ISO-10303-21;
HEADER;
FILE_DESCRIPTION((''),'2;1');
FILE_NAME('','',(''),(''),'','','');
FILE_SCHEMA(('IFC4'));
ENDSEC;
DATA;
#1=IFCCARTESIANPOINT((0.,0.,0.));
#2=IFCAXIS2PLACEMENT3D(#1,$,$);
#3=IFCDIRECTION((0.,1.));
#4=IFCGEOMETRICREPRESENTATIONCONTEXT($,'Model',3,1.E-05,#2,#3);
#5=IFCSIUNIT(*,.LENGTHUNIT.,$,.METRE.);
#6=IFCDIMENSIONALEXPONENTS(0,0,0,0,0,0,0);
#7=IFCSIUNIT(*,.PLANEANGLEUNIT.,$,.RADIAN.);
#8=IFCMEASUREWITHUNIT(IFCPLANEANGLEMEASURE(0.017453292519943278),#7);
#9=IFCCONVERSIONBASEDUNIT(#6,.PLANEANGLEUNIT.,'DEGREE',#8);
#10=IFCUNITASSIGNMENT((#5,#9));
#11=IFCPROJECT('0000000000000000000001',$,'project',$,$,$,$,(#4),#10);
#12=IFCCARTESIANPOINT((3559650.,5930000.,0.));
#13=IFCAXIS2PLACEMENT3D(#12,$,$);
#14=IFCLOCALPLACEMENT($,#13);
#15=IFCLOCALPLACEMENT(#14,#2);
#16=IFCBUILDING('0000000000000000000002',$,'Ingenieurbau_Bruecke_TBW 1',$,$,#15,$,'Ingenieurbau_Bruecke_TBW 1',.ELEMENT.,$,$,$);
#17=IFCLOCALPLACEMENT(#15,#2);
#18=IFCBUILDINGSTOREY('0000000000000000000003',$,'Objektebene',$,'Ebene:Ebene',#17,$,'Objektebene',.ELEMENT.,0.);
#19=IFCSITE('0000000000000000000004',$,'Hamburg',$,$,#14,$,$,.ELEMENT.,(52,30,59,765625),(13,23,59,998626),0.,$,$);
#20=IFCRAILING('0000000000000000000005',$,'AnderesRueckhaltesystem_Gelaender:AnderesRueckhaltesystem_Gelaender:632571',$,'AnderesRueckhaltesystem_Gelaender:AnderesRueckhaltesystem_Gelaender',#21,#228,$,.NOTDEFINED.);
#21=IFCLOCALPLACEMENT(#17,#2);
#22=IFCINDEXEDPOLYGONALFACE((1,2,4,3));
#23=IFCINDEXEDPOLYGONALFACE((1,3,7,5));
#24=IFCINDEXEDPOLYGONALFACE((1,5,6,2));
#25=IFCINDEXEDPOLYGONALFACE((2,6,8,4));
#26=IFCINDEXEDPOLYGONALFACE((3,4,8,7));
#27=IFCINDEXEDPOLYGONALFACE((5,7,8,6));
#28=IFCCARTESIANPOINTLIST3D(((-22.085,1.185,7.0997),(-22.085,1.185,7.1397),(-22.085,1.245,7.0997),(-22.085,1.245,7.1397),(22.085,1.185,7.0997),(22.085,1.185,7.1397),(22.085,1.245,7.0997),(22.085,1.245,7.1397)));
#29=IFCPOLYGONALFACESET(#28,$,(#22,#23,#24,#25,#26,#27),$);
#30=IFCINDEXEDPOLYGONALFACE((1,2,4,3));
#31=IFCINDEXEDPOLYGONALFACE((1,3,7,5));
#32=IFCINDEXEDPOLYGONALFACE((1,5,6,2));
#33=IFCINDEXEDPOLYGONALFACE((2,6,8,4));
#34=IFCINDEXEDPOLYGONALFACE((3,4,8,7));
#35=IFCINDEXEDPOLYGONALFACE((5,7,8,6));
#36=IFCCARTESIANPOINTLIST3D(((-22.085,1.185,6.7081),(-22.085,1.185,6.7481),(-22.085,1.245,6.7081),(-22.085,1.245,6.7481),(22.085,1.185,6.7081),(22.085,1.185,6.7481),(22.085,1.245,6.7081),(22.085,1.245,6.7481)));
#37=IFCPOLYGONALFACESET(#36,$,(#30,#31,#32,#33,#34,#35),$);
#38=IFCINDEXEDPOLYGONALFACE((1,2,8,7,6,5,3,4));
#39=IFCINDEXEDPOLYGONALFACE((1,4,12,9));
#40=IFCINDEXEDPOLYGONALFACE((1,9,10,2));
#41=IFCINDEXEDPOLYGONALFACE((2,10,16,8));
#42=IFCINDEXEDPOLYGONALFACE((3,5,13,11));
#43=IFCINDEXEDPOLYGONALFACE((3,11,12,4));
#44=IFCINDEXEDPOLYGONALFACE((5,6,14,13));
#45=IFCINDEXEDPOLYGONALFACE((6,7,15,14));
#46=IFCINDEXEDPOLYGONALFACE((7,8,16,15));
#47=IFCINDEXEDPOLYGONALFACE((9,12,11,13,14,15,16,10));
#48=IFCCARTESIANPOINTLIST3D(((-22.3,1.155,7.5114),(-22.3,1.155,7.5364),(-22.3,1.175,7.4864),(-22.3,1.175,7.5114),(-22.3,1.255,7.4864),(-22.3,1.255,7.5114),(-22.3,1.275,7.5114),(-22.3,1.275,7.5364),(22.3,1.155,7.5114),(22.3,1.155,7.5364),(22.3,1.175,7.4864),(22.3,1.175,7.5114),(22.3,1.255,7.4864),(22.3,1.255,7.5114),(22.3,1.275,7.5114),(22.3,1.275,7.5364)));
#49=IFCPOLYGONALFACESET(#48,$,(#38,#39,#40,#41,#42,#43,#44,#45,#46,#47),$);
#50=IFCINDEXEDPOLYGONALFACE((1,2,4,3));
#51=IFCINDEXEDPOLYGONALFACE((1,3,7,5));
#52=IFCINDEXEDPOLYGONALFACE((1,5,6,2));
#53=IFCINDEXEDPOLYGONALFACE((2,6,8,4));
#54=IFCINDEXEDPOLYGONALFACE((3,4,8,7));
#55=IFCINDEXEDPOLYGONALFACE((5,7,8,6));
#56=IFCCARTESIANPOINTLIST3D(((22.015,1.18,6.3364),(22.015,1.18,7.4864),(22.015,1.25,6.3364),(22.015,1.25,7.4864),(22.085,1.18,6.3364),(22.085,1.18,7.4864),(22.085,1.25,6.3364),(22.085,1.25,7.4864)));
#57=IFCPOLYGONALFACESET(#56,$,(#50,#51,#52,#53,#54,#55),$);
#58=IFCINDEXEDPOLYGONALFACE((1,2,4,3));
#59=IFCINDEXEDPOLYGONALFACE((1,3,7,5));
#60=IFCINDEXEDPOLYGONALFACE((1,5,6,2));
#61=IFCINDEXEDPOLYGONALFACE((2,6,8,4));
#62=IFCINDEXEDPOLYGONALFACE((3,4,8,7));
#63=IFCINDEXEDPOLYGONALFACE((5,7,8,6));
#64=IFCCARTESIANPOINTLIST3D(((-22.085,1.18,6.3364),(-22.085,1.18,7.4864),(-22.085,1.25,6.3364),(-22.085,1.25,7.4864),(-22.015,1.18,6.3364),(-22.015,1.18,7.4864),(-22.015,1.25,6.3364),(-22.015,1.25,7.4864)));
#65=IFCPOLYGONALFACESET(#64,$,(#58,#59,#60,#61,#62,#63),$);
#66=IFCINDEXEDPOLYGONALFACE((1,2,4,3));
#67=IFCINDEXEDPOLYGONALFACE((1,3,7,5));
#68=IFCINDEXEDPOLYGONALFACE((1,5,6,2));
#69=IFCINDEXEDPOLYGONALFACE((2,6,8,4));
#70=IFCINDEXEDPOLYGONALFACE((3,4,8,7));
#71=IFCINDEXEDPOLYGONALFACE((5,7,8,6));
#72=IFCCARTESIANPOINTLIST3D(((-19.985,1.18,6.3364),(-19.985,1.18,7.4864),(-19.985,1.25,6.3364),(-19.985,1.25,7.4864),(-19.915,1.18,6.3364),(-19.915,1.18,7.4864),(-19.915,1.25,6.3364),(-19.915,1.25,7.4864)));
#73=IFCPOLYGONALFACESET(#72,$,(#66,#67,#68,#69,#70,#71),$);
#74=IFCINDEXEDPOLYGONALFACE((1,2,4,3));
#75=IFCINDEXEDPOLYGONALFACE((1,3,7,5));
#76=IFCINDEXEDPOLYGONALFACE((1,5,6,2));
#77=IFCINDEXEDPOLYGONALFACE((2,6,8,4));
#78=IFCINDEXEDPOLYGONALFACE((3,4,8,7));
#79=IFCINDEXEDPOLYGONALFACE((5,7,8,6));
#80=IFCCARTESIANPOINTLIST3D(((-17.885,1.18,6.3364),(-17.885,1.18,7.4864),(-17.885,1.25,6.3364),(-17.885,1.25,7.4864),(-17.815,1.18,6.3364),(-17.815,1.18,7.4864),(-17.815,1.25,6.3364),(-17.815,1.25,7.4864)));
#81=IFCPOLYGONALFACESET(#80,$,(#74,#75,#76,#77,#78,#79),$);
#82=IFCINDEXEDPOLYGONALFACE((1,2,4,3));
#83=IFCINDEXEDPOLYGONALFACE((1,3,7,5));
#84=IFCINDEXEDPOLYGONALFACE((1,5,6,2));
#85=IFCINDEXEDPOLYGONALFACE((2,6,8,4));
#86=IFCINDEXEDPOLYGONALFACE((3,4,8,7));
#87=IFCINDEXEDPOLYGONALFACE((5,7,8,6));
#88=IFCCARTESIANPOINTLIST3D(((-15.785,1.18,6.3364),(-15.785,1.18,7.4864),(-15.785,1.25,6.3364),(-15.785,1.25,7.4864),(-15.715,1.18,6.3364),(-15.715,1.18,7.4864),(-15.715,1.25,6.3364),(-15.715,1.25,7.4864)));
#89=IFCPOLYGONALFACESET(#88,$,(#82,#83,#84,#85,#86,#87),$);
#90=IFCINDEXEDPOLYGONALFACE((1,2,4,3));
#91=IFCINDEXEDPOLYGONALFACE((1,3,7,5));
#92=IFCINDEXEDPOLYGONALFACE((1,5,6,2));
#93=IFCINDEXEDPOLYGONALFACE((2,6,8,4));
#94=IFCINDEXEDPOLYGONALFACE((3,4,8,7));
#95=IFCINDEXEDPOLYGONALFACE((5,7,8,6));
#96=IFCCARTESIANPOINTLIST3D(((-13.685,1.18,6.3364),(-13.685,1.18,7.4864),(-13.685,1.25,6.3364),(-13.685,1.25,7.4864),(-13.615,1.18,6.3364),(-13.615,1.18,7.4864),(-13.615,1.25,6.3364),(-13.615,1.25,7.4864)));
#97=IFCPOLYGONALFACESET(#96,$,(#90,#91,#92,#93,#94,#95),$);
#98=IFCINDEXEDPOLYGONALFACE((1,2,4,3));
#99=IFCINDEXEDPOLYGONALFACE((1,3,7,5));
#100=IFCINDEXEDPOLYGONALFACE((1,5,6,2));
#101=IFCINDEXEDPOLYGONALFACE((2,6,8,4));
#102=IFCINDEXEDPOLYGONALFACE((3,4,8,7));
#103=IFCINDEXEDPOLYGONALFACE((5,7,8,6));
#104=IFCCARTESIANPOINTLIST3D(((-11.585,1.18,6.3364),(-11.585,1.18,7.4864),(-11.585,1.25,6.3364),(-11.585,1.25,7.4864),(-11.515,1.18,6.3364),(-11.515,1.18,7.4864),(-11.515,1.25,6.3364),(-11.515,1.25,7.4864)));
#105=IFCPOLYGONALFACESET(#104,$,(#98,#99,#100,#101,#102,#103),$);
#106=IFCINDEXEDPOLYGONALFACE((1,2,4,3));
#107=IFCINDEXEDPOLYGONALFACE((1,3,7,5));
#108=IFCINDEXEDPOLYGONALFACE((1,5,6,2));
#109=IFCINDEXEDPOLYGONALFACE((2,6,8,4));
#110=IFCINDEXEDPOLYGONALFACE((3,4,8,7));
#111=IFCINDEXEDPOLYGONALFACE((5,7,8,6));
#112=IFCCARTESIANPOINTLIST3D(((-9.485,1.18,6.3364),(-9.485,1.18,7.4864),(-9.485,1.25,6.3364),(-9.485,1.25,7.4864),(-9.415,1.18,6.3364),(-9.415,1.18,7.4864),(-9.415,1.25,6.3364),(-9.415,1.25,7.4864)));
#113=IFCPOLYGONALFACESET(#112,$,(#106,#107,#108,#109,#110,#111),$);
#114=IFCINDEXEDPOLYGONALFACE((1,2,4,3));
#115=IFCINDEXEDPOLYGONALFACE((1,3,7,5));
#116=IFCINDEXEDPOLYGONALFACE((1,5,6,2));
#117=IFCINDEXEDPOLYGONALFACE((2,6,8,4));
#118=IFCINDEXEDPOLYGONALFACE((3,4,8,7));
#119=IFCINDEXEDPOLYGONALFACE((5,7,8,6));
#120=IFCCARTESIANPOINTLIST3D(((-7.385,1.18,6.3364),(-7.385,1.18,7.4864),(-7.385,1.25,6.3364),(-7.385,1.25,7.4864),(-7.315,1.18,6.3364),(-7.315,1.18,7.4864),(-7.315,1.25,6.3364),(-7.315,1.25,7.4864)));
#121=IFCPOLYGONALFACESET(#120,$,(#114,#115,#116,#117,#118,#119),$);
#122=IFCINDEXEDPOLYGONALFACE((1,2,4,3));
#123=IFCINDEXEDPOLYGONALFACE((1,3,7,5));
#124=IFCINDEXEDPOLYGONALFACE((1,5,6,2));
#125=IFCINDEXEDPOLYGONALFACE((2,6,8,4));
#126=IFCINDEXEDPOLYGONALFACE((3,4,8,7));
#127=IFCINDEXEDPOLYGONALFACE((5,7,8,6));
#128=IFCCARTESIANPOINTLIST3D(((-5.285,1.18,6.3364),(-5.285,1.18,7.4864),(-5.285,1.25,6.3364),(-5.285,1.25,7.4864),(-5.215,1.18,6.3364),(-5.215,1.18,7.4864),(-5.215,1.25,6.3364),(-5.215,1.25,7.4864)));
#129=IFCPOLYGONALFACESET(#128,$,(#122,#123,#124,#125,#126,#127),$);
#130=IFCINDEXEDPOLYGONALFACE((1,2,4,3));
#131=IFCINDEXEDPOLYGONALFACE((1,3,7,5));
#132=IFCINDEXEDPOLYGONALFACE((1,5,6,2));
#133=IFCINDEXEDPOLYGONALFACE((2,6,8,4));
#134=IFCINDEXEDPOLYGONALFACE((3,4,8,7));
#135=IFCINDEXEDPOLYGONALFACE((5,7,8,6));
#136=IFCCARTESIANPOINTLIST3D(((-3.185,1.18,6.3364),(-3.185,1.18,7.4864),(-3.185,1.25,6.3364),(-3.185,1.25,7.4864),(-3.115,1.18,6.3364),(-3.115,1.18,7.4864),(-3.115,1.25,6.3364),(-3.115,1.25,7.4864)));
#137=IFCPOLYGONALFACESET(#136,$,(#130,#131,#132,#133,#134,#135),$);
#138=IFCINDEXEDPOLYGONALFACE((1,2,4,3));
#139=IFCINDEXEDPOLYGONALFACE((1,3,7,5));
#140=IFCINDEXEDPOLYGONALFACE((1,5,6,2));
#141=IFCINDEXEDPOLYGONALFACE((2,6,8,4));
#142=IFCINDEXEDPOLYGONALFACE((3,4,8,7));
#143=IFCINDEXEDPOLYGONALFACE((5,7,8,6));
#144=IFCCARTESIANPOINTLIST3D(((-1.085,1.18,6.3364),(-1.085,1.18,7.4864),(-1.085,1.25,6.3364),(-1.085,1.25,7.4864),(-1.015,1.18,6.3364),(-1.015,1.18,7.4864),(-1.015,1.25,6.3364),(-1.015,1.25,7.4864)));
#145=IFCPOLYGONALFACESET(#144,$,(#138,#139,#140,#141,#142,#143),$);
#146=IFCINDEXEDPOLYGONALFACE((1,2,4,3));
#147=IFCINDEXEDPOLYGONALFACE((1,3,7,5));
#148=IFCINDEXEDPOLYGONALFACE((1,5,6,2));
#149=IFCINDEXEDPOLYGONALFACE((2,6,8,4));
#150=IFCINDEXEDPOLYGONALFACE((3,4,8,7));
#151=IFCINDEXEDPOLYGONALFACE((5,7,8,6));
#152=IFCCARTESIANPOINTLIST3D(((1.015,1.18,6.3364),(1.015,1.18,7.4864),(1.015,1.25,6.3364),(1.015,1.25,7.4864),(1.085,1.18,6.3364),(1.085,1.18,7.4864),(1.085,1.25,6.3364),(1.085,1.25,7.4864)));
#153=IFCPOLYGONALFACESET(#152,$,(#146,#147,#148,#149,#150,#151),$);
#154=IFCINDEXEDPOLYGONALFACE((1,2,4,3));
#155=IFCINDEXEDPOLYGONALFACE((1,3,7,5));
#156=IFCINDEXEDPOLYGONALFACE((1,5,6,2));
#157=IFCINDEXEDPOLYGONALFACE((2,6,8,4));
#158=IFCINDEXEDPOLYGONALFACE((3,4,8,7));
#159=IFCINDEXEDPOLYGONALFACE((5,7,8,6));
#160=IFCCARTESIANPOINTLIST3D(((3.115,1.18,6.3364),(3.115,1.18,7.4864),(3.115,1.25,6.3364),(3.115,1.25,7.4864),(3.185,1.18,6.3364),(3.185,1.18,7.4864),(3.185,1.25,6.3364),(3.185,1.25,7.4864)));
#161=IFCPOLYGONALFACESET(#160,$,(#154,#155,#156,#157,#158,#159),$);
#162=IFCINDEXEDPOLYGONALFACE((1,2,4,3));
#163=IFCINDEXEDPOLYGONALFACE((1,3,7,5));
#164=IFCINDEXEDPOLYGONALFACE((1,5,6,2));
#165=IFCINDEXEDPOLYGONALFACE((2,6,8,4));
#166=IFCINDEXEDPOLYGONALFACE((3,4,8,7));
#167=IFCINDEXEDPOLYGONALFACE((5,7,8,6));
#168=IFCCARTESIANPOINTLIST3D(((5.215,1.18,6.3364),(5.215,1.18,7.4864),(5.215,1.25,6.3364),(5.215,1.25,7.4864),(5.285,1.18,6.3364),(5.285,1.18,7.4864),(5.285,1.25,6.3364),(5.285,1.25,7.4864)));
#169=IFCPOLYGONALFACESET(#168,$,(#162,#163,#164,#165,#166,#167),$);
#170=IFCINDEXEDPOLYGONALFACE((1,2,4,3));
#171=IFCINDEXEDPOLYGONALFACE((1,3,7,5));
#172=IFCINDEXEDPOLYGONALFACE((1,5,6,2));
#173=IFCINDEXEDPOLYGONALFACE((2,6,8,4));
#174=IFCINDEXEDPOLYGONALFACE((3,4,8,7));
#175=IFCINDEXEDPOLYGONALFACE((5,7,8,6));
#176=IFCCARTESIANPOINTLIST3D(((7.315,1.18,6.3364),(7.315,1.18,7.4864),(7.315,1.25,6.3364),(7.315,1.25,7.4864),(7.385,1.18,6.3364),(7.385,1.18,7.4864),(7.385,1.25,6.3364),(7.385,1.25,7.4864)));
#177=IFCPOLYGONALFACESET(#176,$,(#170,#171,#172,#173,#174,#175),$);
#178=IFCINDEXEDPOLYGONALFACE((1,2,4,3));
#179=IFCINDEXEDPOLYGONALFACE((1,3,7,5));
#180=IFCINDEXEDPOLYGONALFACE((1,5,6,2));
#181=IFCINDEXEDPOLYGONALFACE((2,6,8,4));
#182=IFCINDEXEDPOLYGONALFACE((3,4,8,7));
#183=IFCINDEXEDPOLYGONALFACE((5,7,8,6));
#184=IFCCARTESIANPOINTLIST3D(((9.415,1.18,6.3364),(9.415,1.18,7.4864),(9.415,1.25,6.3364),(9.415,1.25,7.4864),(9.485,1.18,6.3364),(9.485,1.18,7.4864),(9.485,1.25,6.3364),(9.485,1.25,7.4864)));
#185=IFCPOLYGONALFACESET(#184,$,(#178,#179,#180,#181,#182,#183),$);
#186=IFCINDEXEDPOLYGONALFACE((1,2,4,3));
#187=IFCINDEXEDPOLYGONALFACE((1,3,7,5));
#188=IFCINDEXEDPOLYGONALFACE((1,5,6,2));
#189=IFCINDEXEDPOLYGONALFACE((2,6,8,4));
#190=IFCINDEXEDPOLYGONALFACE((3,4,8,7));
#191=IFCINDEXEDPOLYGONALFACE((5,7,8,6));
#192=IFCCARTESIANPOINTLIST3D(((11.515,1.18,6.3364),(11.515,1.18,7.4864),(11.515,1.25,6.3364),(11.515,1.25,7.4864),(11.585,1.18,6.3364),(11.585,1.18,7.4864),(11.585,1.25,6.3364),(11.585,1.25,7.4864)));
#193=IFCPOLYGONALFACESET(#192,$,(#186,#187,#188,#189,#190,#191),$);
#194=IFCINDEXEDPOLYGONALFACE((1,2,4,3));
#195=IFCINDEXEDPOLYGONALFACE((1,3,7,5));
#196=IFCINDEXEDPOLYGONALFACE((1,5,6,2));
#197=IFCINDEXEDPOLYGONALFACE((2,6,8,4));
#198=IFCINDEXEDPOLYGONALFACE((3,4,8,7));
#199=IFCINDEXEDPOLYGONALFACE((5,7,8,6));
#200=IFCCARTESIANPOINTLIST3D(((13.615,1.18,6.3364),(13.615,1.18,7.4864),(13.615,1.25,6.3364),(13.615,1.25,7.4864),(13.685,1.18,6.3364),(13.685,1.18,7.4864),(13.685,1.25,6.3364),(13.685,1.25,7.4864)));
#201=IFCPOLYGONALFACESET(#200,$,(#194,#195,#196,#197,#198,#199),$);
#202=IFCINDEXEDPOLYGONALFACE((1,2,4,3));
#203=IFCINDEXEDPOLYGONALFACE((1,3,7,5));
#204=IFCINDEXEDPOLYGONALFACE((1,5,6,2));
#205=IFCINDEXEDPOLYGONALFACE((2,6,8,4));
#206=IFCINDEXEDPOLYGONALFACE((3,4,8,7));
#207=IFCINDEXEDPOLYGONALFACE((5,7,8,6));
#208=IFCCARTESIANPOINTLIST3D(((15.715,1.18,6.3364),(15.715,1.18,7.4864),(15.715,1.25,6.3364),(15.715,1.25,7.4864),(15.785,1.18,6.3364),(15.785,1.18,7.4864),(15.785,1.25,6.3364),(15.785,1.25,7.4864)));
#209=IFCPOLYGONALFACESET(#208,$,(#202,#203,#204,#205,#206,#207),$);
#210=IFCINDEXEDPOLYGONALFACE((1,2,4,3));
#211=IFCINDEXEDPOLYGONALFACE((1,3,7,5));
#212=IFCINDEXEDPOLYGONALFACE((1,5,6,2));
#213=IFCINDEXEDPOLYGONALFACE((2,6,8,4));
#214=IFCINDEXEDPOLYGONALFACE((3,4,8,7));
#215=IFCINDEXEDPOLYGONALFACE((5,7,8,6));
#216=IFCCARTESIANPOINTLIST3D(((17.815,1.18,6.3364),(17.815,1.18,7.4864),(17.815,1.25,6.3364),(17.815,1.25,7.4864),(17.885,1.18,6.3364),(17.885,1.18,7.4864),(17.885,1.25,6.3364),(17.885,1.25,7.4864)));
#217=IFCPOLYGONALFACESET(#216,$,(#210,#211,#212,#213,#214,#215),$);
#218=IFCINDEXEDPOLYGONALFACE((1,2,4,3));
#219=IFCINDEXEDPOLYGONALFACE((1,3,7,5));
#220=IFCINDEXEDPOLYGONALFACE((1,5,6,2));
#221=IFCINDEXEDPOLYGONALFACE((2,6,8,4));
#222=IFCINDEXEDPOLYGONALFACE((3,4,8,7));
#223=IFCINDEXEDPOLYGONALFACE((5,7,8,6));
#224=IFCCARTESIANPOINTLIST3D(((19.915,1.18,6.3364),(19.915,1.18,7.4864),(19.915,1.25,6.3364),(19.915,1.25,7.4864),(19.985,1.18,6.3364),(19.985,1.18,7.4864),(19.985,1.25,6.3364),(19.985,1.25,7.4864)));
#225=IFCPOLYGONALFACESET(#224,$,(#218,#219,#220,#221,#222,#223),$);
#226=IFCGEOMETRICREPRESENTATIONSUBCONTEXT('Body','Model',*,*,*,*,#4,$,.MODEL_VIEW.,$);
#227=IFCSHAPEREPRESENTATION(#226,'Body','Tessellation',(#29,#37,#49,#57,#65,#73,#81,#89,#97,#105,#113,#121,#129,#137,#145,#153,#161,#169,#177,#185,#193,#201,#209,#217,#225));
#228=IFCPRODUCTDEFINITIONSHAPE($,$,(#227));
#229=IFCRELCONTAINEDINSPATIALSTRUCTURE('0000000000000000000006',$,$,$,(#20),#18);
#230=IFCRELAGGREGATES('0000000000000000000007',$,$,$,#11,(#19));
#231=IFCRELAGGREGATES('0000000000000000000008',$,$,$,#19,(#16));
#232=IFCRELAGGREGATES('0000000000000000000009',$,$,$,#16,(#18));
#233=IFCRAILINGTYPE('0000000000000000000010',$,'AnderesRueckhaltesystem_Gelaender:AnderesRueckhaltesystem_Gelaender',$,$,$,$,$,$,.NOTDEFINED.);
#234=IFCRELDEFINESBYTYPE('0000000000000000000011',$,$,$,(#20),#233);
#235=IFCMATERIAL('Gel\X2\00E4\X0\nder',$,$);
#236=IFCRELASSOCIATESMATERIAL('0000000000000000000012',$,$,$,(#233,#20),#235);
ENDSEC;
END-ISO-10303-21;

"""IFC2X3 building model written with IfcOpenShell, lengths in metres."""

from ifc_helpers import new_model, entity, si_unit, converted_unit, direction, frame, frame_2d, origin, origin_2d_with_axis, place, context, subcontext, project, spatial, polyline, rectangle, outline, extrude, source, transform, mapped, material, type_object, type_shapes, element, save


model = new_model("IFC2X3")

# Units and contexts
model_context = context("Model", 3, precision=1e-05, world=origin(), true_north=direction((0.0, 1.0)))
body_context = subcontext(model_context, "Body", "Model", "MODEL_VIEW")
ifc_project = project(units=[si_unit("LENGTHUNIT", "METRE"), converted_unit("PLANEANGLEUNIT", "DEGREE", entity("IfcPlaneAngleMeasure", 0.017453292519943278), si_unit("PLANEANGLEUNIT", "RADIAN"), dimensions=[0, 0, 0, 0, 0, 0, 0])], contexts=[model_context])

# Site, building, storey
site_placement = place(None, frame((3559650.0, 5930000.0, 0.0)))
site = spatial("IfcSite", under=ifc_project, at=site_placement, Name="Hamburg", CompositionType="ELEMENT", RefLatitude=(52, 30, 59, 765625), RefLongitude=(13, 23, 59, 998626), RefElevation=0.0)
building_placement = place(site_placement, origin())
building = spatial("IfcBuilding", under=site, at=building_placement, Name="Ingenieurbau_Bruecke_TBW 1", LongName="Ingenieurbau_Bruecke_TBW 1", CompositionType="ELEMENT")
storey_placement = place(building_placement, origin())
storey = spatial("IfcBuildingStorey", under=building, at=storey_placement, Name="Objektebene", ObjectType="Ebene:Ebene", LongName="Objektebene", CompositionType="ELEMENT", Elevation=0.0)

# Railing
ifc_material_1 = material(Name="Geländer")
railing_type = type_object("IfcRailingType", Name="AnderesRueckhaltesystem_Gelaender:AnderesRueckhaltesystem_Gelaender", PredefinedType="NOTDEFINED", material=ifc_material_1)
shared_shape_1 = source(origin(), body_context, "Body", "SweptSolid", [
    extrude(rectangle(XDim=44.17, YDim=0.06, at=origin_2d_with_axis()), frame((0.0, 0.0, 5.3133), z_axis=(0.0, 0.0, 1.0), x_axis=(-1.0, 0.0, 0.0)), (0.0, 0.0, 1.0), 0.04),
    extrude(rectangle(XDim=44.17, YDim=0.06, at=origin_2d_with_axis()), frame((0.0, 0.0, 4.9217), z_axis=(0.0, 0.0, 1.0), x_axis=(-1.0, 0.0, 0.0)), (0.0, 0.0, 1.0), 0.04),
    extrude(outline(polyline([(0.0, -0.06), (0.025, -0.06), (0.025, 0.06), (0.0, 0.06), (0.0, 0.04), (-0.025, 0.04), (-0.025, -0.04), (0.0, -0.04), (0.0, -0.06)])), frame((-22.3, 0.0, 5.725), z_axis=(1.0, 0.0, 0.0), x_axis=(0.0, 0.0, 1.0)), (0.0, 0.0, 1.0), 44.6),
    extrude(rectangle(XDim=0.07, YDim=0.07, at=origin_2d_with_axis()), frame((22.05, 0.0, 4.55), z_axis=(0.0, 0.0, 1.0), x_axis=(-1.0, 0.0, 0.0)), (0.0, 0.0, 1.0), 1.15),
    extrude(rectangle(XDim=0.07, YDim=0.07, at=origin_2d_with_axis()), frame((-22.05, 0.0, 4.55), z_axis=(0.0, 0.0, 1.0), x_axis=(-1.0, 0.0, 0.0)), (0.0, 0.0, 1.0), 1.15),
    extrude(rectangle(XDim=0.07, YDim=0.07, at=origin_2d_with_axis()), frame((-19.95, 0.0, 4.55), z_axis=(0.0, 0.0, 1.0), x_axis=(-1.0, 0.0, 0.0)), (0.0, 0.0, 1.0), 1.15),
    extrude(rectangle(XDim=0.07, YDim=0.07, at=origin_2d_with_axis()), frame((-17.85, 0.0, 4.55), z_axis=(0.0, 0.0, 1.0), x_axis=(-1.0, 0.0, 0.0)), (0.0, 0.0, 1.0), 1.15),
    extrude(rectangle(XDim=0.07, YDim=0.07, at=origin_2d_with_axis()), frame((-15.75, 0.0, 4.55), z_axis=(0.0, 0.0, 1.0), x_axis=(-1.0, 0.0, 0.0)), (0.0, 0.0, 1.0), 1.15),
    extrude(rectangle(XDim=0.07, YDim=0.07, at=origin_2d_with_axis()), frame((-13.65, 0.0, 4.55), z_axis=(0.0, 0.0, 1.0), x_axis=(-1.0, 0.0, 0.0)), (0.0, 0.0, 1.0), 1.15),
    extrude(rectangle(XDim=0.07, YDim=0.07, at=origin_2d_with_axis()), frame((-11.55, 0.0, 4.55), z_axis=(0.0, 0.0, 1.0), x_axis=(-1.0, 0.0, 0.0)), (0.0, 0.0, 1.0), 1.15),
    extrude(rectangle(XDim=0.07, YDim=0.07, at=frame_2d((0.0, 0.0), x_axis=(1.0, 0.0))), frame((-9.45, 0.0, 4.55), z_axis=(0.0, 0.0, 1.0), x_axis=(-1.0, 0.0, 0.0)), (0.0, 0.0, 1.0), 1.15),
    extrude(rectangle(XDim=0.07, YDim=0.07, at=origin_2d_with_axis()), frame((-7.35, 0.0, 4.55), z_axis=(0.0, 0.0, 1.0), x_axis=(-1.0, 0.0, 0.0)), (0.0, 0.0, 1.0), 1.15),
    extrude(rectangle(XDim=0.07, YDim=0.07, at=origin_2d_with_axis()), frame((-5.25, 0.0, 4.55), z_axis=(0.0, 0.0, 1.0), x_axis=(-1.0, 0.0, 0.0)), (0.0, 0.0, 1.0), 1.15),
    extrude(rectangle(XDim=0.07, YDim=0.07, at=origin_2d_with_axis()), frame((-3.15, 0.0, 4.55), z_axis=(0.0, 0.0, 1.0), x_axis=(-1.0, 0.0, 0.0)), (0.0, 0.0, 1.0), 1.15),
    extrude(rectangle(XDim=0.07, YDim=0.07, at=origin_2d_with_axis()), frame((-1.05, 0.0, 4.55), z_axis=(0.0, 0.0, 1.0), x_axis=(-1.0, 0.0, 0.0)), (0.0, 0.0, 1.0), 1.15),
    extrude(rectangle(XDim=0.07, YDim=0.07, at=origin_2d_with_axis()), frame((1.05, 0.0, 4.55), z_axis=(0.0, 0.0, 1.0), x_axis=(-1.0, 0.0, 0.0)), (0.0, 0.0, 1.0), 1.15),
    extrude(rectangle(XDim=0.07, YDim=0.07, at=origin_2d_with_axis()), frame((3.15, 0.0, 4.55), z_axis=(0.0, 0.0, 1.0), x_axis=(-1.0, 0.0, 0.0)), (0.0, 0.0, 1.0), 1.15),
    extrude(rectangle(XDim=0.07, YDim=0.07, at=origin_2d_with_axis()), frame((5.25, 0.0, 4.55), z_axis=(0.0, 0.0, 1.0), x_axis=(0.0, 1.0, 0.0)), (0.0, 0.0, 1.0), 1.15),
    extrude(rectangle(XDim=0.07, YDim=0.07, at=origin_2d_with_axis()), frame((7.35, 0.0, 4.55), z_axis=(0.0, 0.0, 1.0), x_axis=(-1.0, 0.0, 0.0)), (0.0, 0.0, 1.0), 1.15),
    extrude(rectangle(XDim=0.07, YDim=0.07, at=origin_2d_with_axis()), frame((9.45, 0.0, 4.55), z_axis=(0.0, 0.0, 1.0), x_axis=(-1.0, 0.0, 0.0)), (0.0, 0.0, 1.0), 1.15),
    extrude(rectangle(XDim=0.07, YDim=0.07, at=origin_2d_with_axis()), frame((11.55, 0.0, 4.55), z_axis=(0.0, 0.0, 1.0), x_axis=(0.0, 1.0, 0.0)), (0.0, 0.0, 1.0), 1.15),
    extrude(rectangle(XDim=0.07, YDim=0.07, at=origin_2d_with_axis()), frame((13.65, 0.0, 4.55), z_axis=(0.0, 0.0, 1.0), x_axis=(-1.0, 0.0, 0.0)), (0.0, 0.0, 1.0), 1.15),
    extrude(rectangle(XDim=0.07, YDim=0.07, at=origin_2d_with_axis()), frame((15.75, 0.0, 4.55), z_axis=(0.0, 0.0, 1.0), x_axis=(0.0, 1.0, 0.0)), (0.0, 0.0, 1.0), 1.15),
    extrude(rectangle(XDim=0.07, YDim=0.07, at=origin_2d_with_axis()), frame((17.85, 0.0, 4.55), z_axis=(0.0, 0.0, 1.0), x_axis=(-1.0, 0.0, 0.0)), (0.0, 0.0, 1.0), 1.15),
    extrude(rectangle(XDim=0.07, YDim=0.07, at=origin_2d_with_axis()), frame((19.95, 0.0, 4.55), z_axis=(0.0, 0.0, 1.0), x_axis=(-1.0, 0.0, 0.0)), (0.0, 0.0, 1.0), 1.15),
])
type_shapes(railing_type, [shared_shape_1])
railing_placement = place(storey_placement, frame((0.0, 1.215, 1.7864)))
element("IfcRailing", 1, at=railing_placement, inside=storey, type_object=railing_type, material=ifc_material_1, Name="AnderesRueckhaltesystem_Gelaender:AnderesRueckhaltesystem_Gelaender:632571", ObjectType="AnderesRueckhaltesystem_Gelaender:AnderesRueckhaltesystem_Gelaender", PredefinedType="NOTDEFINED", context=body_context, shape_type="MappedRepresentation", body=[
    mapped(shared_shape_1, transform((0.0, 0.0, 0.0), scale=1.0)),
])

save(model, "model.ifc")
